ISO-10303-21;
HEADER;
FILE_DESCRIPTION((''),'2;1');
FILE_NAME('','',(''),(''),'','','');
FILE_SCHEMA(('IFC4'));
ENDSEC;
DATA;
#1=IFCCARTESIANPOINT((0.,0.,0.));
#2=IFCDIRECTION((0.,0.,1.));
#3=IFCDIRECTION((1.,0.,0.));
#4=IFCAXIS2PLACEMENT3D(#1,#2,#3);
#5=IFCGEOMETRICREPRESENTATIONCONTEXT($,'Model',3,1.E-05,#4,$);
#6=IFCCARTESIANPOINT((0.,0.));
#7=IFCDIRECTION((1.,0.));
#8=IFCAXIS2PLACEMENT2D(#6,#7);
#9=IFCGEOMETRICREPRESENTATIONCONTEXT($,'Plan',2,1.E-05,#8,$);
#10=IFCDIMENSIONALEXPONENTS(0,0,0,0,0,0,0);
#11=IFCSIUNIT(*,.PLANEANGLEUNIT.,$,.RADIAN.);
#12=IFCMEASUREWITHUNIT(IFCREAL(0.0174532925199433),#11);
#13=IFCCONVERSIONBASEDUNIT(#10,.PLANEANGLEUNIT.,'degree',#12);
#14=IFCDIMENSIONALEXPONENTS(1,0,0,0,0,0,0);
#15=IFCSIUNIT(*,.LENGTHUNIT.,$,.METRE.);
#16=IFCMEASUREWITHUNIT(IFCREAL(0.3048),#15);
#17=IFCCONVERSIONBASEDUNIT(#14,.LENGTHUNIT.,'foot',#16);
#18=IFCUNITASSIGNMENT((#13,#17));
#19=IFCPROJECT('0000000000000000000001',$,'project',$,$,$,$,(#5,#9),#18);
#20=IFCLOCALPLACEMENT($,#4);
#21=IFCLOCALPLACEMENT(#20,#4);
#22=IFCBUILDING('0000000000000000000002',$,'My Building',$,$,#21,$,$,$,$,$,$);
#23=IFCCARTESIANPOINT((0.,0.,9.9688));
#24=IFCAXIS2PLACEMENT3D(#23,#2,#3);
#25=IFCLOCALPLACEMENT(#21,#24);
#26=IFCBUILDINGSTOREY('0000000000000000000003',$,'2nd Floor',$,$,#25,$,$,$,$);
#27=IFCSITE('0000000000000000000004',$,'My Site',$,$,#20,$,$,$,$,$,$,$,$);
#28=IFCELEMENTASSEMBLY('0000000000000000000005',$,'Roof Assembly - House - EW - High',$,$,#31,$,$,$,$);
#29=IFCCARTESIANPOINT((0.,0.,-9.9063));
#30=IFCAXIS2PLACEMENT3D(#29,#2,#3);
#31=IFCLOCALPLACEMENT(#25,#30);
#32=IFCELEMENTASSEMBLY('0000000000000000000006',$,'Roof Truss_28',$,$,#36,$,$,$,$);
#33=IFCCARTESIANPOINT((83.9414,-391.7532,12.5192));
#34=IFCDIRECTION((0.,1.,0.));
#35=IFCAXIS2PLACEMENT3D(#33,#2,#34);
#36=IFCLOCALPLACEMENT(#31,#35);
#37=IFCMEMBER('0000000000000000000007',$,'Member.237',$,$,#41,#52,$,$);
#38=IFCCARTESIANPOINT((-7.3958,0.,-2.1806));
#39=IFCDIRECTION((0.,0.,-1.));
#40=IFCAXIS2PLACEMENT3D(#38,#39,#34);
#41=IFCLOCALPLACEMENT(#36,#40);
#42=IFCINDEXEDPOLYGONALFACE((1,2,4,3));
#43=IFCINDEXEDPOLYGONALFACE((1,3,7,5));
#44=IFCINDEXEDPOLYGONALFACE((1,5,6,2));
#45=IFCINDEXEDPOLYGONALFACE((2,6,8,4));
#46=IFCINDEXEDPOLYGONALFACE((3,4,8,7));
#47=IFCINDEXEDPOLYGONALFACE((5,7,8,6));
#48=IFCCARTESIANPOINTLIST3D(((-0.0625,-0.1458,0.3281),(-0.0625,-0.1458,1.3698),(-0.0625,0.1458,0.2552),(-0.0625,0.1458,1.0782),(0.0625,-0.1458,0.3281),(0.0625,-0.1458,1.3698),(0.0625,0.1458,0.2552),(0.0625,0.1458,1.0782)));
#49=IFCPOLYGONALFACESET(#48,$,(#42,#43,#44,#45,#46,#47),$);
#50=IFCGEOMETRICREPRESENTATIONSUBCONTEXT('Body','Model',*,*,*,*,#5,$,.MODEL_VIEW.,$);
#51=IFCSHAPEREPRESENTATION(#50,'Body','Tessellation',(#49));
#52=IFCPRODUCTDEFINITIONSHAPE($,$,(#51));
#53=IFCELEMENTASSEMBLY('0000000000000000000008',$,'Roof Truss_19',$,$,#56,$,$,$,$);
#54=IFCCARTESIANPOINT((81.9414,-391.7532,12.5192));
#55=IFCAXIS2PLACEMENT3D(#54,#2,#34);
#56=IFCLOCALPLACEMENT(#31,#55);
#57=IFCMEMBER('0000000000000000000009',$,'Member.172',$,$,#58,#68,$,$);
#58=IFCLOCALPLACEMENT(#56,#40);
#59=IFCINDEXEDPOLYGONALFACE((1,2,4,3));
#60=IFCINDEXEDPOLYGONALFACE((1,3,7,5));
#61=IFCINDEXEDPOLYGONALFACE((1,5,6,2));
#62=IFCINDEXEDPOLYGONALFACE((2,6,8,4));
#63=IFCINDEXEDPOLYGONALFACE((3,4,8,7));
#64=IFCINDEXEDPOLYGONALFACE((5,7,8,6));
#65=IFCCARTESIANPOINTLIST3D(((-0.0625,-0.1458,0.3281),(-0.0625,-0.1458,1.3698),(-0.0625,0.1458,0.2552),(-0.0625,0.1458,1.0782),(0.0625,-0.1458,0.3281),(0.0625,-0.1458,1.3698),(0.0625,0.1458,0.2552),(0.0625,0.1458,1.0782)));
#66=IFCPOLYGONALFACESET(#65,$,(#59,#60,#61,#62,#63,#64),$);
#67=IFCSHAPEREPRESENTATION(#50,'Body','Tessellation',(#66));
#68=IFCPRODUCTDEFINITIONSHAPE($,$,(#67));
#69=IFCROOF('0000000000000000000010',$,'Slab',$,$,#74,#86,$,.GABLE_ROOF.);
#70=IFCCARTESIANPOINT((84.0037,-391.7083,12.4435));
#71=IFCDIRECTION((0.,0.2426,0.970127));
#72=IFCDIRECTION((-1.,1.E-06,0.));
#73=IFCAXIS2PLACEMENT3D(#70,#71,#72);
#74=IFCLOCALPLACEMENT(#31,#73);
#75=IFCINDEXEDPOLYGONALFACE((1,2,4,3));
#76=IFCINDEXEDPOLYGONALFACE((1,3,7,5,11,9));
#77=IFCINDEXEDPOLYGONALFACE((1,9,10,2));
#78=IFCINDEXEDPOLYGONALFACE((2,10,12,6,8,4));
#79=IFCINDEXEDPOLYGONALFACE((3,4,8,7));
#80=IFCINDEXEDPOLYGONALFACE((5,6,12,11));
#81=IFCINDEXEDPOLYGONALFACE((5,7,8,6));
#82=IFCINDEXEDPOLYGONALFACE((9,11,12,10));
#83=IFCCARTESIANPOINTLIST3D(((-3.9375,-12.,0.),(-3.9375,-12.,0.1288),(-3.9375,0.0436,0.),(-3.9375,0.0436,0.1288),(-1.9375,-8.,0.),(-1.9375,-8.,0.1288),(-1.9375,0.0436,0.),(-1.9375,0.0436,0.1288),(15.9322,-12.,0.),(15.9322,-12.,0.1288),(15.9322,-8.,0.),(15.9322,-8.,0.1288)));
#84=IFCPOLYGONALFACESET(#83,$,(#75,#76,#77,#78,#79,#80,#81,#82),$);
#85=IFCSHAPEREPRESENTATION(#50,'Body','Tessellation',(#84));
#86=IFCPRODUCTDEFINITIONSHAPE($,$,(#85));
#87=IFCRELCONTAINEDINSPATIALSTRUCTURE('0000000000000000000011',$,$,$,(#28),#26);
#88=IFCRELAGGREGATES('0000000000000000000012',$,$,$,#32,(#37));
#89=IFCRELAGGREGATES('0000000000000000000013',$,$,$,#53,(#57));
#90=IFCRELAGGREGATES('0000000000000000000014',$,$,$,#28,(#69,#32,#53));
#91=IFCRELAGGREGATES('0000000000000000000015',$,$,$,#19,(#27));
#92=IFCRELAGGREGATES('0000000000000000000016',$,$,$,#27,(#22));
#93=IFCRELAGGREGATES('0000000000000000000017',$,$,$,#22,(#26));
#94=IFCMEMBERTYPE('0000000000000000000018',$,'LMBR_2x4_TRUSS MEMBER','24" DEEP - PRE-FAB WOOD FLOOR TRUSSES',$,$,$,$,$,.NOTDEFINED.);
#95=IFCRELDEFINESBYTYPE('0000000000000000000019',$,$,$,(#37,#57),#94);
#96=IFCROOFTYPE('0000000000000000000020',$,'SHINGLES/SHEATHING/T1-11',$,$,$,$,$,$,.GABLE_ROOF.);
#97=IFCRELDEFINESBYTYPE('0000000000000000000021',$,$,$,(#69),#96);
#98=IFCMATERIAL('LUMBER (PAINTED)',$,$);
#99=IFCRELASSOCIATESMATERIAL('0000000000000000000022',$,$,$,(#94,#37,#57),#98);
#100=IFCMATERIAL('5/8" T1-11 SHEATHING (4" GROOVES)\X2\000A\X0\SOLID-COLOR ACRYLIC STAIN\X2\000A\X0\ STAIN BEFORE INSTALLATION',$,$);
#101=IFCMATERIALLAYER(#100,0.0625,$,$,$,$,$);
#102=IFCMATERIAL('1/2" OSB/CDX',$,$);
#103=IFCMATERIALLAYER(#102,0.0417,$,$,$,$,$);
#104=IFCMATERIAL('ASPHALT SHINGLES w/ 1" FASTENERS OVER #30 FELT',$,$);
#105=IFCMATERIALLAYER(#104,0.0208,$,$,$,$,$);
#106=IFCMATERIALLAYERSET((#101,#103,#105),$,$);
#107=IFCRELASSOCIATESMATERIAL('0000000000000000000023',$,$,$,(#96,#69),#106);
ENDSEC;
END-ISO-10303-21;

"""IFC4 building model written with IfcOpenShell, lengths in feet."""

from ifc_helpers import new_model, entity, si_unit, converted_unit, frame, origin_with_axes, origin_2d_with_axis, place, context, subcontext, project, spatial, indexed_curve, outline, extrude, clip, halfspace, material, layer, layer_set, layer_usage, material_profile, profile_set, profile_usage, type_object, element, aggregate, save


model = new_model("IFC4")

# Units and contexts
model_context = context("Model", 3, precision=1e-05, world=origin_with_axes())
plan_context = context("Plan", 2, precision=1e-05, world=origin_2d_with_axis())
body_context = subcontext(model_context, "Body", "Model", "MODEL_VIEW")
ifc_project = project(units=[converted_unit("PLANEANGLEUNIT", "degree", entity("IfcReal", 0.0174532925199433), si_unit("PLANEANGLEUNIT", "RADIAN"), dimensions=[0, 0, 0, 0, 0, 0, 0]), converted_unit("LENGTHUNIT", "foot", entity("IfcReal", 0.3048), si_unit("LENGTHUNIT", "METRE"), dimensions=[1, 0, 0, 0, 0, 0, 0])], contexts=[model_context, plan_context])

# Site, building, storey
site_placement = place(None, origin_with_axes())
site = spatial("IfcSite", under=ifc_project, at=site_placement, Name="My Site")
building_placement = place(site_placement, origin_with_axes())
building = spatial("IfcBuilding", under=site, at=building_placement, Name="My Building")
storey_placement = place(building_placement, frame((0.0, 0.0, 9.9688), z_axis=(0.0, 0.0, 1.0), x_axis=(1.0, 0.0, 0.0)))
storey = spatial("IfcBuildingStorey", under=building, at=storey_placement, Name="2nd Floor")

# Element assemblies, members, roof
assembly_1_placement = place(storey_placement, frame((0.0, 0.0, -9.9063), z_axis=(0.0, 0.0, 1.0), x_axis=(1.0, 0.0, 0.0)))
assembly_1 = element("IfcElementAssembly", 1, at=assembly_1_placement, inside=storey, Name="Roof Assembly - House - EW - High")
assembly_2_placement = place(assembly_1_placement, frame((83.9414, -391.7532, 12.5192), z_axis=(0.0, 0.0, 1.0), x_axis=(0.0, 1.0, 0.0)))
assembly_2 = element("IfcElementAssembly", 2, at=assembly_2_placement, Name="Roof Truss_28")
ifc_material_1 = material(Name="LUMBER (PAINTED)")
ifc_material_profile_1 = material_profile(ifc_material_1, outline(indexed_curve([(-0.0625, -0.1458), (0.0625, -0.1458), (0.0625, 0.1458), (-0.0625, 0.1458), (-0.0625, -0.1458)])))
ifc_profile_set_1 = profile_set([ifc_material_profile_1])
member_type_1 = type_object("IfcMemberType", Name="LMBR_2x4_TRUSS MEMBER", Description="24\" DEEP - PRE-FAB WOOD FLOOR TRUSSES", PredefinedType="NOTDEFINED", material=ifc_profile_set_1)
ifc_profile_usage_1 = profile_usage(ifc_profile_set_1)
member_1_placement = place(assembly_2_placement, frame((-7.3958, 0.0, -2.1806), z_axis=(0.0, 0.0, -1.0), x_axis=(0.0, 1.0, 0.0)))
member_1 = element("IfcMember", 3, at=member_1_placement, type_object=member_type_1, material=ifc_profile_usage_1, Name="Member.237", context=body_context, shape_type="Clipping", body=[
    clip(clip(extrude(outline(indexed_curve([(-0.0625, -0.1458), (0.0625, -0.1458), (0.0625, 0.1458), (-0.0625, 0.1458), (-0.0625, -0.1458)])), origin_with_axes(), (0.0, 0.0, 1.0), 1.3698), halfspace(frame((0.0, 7.5424, -1.5944), z_axis=(0.0, -0.242599, -0.970127), x_axis=(-1.0, 0.000001, 0.0)), False)), halfspace(frame((397.5032, -0.1458, 1.3698), z_axis=(0.0, 0.707107, 0.707107), x_axis=(1.0, 0.0, 0.0)), False)),
])
assembly_3_placement = place(assembly_1_placement, frame((81.9414, -391.7532, 12.5192), z_axis=(0.0, 0.0, 1.0), x_axis=(0.0, 1.0, 0.0)))
assembly_3 = element("IfcElementAssembly", 4, at=assembly_3_placement, Name="Roof Truss_19")
ifc_profile_usage_2 = profile_usage(ifc_profile_set_1)
member_2_placement = place(assembly_3_placement, frame((-7.3958, 0.0, -2.1806), z_axis=(0.0, 0.0, -1.0), x_axis=(0.0, 1.0, 0.0)))
member_2 = element("IfcMember", 5, at=member_2_placement, type_object=member_type_1, material=ifc_profile_usage_2, Name="Member.172", context=body_context, shape_type="Clipping", body=[
    clip(clip(extrude(outline(indexed_curve([(-0.0625, -0.1458), (0.0625, -0.1458), (0.0625, 0.1458), (-0.0625, 0.1458), (-0.0625, -0.1458)])), origin_with_axes(), (0.0, 0.0, 1.0), 1.3698), halfspace(frame((0.0, 7.5424, -1.5944), z_axis=(0.0, -0.242599, -0.970127), x_axis=(-1.0, 0.000001, 0.0)), False)), halfspace(frame((397.5032, -0.1458, 1.3698), z_axis=(0.0, 0.707107, 0.707107), x_axis=(1.0, 0.0, 0.0)), False)),
])
aggregate(assembly_2, [member_1])
aggregate(assembly_3, [member_2])
ifc_material_2 = material(Name="5/8\" T1-11 SHEATHING (4\" GROOVES)\nSOLID-COLOR ACRYLIC STAIN\n STAIN BEFORE INSTALLATION")
ifc_layer_1 = layer(ifc_material_2, 0.0625)
ifc_material_3 = material(Name="1/2\" OSB/CDX")
ifc_layer_2 = layer(ifc_material_3, 0.0417)
ifc_material_4 = material(Name="ASPHALT SHINGLES w/ 1\" FASTENERS OVER #30 FELT")
ifc_layer_3 = layer(ifc_material_4, 0.0208)
ifc_layer_set = layer_set([ifc_layer_1, ifc_layer_2, ifc_layer_3])
ifc_layer_usage = layer_usage(ifc_layer_set, "AXIS3", "POSITIVE", 0.0)
roof_type = type_object("IfcRoofType", Name="SHINGLES/SHEATHING/T1-11", PredefinedType="GABLE_ROOF", material=ifc_layer_set)
roof_placement = place(assembly_1_placement, frame((84.0037, -391.7083, 12.4435), z_axis=(0.0, 0.2426, 0.970127), x_axis=(-1.0, 0.000001, 0.0)))
roof = element("IfcRoof", 6, at=roof_placement, type_object=roof_type, material=ifc_layer_usage, Name="Slab", PredefinedType="GABLE_ROOF", context=body_context, shape_type="SweptSolid", body=[
    extrude(outline(indexed_curve([(15.9322, -8.0), (-1.9375, -8.0), (-1.9375, 0.0436), (-3.9375, 0.0436), (-3.9375, -12.0), (15.9322, -12.0), (15.9322, -8.0)])), None, (0.0, 0.0, 1.0), 0.1288),
])
aggregate(assembly_1, [roof, assembly_2, assembly_3])

save(model, "model.ifc")
